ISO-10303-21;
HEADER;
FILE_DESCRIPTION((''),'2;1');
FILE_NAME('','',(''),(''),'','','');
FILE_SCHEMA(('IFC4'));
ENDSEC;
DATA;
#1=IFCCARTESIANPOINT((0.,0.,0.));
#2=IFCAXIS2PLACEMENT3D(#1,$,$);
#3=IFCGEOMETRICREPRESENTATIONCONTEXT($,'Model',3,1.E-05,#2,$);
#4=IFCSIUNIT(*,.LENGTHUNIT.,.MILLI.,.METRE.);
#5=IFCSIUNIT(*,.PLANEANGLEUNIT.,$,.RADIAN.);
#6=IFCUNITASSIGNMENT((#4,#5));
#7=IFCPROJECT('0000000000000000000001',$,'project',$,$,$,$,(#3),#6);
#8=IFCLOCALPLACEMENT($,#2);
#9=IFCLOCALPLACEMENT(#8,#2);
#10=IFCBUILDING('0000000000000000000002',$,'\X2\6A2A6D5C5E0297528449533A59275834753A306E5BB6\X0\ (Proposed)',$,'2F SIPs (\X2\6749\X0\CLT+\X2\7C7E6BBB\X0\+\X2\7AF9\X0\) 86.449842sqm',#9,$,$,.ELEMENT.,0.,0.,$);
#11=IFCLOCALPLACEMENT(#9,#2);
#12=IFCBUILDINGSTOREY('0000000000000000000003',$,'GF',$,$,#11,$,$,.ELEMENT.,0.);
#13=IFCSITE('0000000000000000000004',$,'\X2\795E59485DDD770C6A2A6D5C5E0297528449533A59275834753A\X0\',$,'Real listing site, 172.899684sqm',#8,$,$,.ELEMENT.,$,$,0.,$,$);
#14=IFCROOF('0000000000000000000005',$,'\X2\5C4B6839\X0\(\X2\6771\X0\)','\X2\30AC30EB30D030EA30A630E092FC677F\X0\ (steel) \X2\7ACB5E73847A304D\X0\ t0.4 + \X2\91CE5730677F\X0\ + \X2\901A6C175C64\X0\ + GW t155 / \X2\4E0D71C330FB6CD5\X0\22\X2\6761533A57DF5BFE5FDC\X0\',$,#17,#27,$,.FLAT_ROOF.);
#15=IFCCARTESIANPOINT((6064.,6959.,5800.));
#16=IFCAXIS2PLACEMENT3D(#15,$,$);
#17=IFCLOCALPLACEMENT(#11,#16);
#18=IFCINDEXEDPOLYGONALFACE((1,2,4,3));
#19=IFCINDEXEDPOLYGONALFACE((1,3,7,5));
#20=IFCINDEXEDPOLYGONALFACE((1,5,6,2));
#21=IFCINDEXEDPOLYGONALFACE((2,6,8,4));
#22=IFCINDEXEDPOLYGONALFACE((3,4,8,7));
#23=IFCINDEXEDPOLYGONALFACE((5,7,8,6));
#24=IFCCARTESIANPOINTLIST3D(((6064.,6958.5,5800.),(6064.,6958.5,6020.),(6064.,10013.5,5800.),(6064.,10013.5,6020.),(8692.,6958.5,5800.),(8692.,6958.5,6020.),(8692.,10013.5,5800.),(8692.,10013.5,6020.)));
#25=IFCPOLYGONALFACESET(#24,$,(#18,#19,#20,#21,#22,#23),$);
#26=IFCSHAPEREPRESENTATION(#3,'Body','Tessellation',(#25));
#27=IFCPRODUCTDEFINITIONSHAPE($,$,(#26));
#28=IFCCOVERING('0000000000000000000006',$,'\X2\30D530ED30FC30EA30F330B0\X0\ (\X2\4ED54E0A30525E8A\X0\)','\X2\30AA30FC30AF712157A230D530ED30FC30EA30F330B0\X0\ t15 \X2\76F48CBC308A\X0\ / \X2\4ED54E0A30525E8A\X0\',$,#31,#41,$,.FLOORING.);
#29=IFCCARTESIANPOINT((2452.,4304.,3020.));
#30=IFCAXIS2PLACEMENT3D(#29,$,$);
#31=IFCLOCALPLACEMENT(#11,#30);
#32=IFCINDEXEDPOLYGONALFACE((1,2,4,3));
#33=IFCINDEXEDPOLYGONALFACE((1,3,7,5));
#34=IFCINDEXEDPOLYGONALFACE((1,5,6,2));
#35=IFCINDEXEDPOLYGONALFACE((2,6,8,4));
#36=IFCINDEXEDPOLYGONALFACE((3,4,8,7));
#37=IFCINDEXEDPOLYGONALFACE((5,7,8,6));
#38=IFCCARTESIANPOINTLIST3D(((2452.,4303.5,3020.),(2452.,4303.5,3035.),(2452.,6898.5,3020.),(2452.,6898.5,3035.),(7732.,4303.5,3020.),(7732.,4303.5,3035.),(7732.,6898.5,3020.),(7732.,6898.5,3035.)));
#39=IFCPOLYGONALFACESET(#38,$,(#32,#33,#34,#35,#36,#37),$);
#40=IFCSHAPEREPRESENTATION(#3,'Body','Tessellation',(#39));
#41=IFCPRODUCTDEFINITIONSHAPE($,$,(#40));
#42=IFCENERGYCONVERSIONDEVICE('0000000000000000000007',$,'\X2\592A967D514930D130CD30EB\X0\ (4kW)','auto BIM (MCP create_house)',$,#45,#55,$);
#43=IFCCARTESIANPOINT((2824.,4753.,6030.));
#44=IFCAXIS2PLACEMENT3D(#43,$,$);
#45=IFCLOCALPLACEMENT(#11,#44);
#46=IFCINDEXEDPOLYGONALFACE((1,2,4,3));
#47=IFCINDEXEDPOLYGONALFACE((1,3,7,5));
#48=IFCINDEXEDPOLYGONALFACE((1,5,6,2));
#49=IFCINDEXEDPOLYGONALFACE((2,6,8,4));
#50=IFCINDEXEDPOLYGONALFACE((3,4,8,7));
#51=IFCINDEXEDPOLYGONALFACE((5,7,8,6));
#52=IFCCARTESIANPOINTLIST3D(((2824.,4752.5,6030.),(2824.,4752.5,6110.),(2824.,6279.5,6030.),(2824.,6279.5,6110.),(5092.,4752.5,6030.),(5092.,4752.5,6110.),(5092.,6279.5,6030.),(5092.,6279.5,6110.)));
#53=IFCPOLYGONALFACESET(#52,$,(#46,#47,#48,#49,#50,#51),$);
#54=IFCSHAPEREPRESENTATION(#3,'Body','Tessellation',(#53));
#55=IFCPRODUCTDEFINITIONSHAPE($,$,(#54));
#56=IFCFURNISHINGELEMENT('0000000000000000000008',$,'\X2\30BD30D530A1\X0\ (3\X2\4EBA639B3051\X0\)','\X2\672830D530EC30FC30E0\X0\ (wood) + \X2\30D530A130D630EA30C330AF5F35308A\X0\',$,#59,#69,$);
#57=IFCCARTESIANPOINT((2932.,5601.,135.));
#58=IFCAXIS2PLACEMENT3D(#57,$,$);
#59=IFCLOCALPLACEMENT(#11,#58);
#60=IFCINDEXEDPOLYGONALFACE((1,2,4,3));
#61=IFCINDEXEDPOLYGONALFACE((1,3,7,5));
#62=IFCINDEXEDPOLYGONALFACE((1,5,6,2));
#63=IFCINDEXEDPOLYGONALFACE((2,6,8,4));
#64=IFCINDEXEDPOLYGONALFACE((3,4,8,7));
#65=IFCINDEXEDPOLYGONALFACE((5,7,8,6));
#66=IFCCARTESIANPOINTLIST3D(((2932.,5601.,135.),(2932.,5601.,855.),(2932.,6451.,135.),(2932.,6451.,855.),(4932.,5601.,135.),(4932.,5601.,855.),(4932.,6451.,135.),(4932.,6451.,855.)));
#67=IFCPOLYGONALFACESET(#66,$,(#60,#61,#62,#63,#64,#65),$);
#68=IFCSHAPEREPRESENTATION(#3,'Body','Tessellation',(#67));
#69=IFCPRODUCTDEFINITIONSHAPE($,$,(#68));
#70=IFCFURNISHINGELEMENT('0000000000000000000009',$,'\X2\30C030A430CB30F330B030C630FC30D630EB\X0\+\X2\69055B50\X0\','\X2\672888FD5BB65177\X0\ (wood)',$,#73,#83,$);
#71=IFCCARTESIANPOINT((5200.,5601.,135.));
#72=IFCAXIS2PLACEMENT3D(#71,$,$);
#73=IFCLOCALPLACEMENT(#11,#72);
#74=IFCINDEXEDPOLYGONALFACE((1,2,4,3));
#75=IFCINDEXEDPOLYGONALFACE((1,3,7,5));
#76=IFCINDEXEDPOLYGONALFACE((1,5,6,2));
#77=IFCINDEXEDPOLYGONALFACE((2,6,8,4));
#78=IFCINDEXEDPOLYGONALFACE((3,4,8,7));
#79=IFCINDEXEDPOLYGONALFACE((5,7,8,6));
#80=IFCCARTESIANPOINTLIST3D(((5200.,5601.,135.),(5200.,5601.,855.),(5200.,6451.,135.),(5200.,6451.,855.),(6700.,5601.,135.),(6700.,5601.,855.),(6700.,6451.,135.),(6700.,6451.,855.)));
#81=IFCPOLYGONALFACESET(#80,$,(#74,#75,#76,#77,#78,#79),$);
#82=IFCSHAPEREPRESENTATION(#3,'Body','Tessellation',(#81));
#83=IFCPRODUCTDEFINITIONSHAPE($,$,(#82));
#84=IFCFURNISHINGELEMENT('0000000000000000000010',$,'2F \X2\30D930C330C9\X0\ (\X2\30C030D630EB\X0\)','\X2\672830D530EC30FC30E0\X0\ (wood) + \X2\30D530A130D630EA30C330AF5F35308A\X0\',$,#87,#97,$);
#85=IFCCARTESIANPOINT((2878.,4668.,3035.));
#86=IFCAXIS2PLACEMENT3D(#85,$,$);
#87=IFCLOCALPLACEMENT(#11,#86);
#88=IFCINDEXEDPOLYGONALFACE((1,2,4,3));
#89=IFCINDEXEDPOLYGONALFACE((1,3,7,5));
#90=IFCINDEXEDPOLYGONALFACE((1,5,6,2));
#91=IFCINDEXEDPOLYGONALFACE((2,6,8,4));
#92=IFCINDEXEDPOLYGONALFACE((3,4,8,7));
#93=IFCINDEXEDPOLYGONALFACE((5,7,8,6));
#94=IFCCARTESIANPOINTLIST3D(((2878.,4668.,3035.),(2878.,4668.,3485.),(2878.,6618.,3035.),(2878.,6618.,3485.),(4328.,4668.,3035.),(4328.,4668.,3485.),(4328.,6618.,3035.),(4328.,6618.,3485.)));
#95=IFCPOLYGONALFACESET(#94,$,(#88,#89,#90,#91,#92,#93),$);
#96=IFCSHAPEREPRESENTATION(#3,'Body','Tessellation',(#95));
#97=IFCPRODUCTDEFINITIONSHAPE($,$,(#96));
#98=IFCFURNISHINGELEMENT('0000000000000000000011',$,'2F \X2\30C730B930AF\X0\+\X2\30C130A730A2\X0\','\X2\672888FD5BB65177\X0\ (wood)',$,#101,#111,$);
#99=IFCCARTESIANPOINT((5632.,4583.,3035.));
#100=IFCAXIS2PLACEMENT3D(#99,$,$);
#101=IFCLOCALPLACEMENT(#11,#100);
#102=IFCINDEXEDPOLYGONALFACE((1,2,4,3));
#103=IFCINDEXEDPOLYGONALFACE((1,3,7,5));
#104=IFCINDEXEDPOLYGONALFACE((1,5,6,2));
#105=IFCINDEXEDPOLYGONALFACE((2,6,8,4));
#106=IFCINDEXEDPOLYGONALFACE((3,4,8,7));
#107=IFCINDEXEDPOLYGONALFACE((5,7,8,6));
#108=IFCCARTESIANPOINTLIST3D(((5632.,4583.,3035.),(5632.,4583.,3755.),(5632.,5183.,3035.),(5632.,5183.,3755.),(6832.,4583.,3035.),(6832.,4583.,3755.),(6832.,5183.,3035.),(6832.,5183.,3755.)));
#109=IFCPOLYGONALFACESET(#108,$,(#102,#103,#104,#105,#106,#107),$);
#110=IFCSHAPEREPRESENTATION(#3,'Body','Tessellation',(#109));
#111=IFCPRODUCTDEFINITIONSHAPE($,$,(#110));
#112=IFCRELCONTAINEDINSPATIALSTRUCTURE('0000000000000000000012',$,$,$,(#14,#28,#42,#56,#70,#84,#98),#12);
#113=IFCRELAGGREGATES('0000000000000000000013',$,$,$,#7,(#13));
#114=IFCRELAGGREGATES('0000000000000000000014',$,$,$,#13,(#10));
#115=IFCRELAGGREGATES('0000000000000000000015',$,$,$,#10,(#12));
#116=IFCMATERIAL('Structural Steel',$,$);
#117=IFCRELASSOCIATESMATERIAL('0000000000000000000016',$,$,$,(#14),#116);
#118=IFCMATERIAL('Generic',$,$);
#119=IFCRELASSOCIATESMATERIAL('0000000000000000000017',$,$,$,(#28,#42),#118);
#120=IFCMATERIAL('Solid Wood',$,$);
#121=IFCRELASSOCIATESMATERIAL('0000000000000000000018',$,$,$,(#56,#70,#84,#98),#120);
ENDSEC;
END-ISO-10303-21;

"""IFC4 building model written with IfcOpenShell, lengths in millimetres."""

from ifc_helpers import new_model, si_unit, frame, frame_2d, origin, place, context, project, spatial, rectangle, extrude, material, element, save


model = new_model("IFC4")

# Units and contexts
model_context = context("Model", 3, precision=1e-05, world=origin())
ifc_project = project(units=[si_unit("LENGTHUNIT", "METRE", prefix="MILLI"), si_unit("PLANEANGLEUNIT", "RADIAN")], contexts=[model_context])

# Site, building, storey
site_placement = place(None, origin())
site = spatial("IfcSite", under=ifc_project, at=site_placement, Name="神奈川県横浜市青葉区大場町", ObjectType="Real listing site, 172.899684sqm", CompositionType="ELEMENT", RefElevation=0.0)
building_placement = place(site_placement, origin())
building = spatial("IfcBuilding", under=site, at=building_placement, Name="横浜市青葉区大場町の家 (Proposed)", ObjectType="2F SIPs (杉CLT+籾殻+竹) 86.449842sqm", CompositionType="ELEMENT", ElevationOfRefHeight=0.0, ElevationOfTerrain=0.0)
storey_placement = place(building_placement, origin())
storey = spatial("IfcBuildingStorey", under=building, at=storey_placement, Name="GF", CompositionType="ELEMENT", Elevation=0.0)

# Shared definitions
ifc_material_1 = material(Name="Solid Wood")

# Roof
ifc_material_2 = material(Name="Structural Steel")
roof_1_placement = place(storey_placement, frame((6064.0, 6959.0, 5800.0)))
element("IfcRoof", 1, at=roof_1_placement, inside=storey, material=ifc_material_2, Name="屋根(東)", Description="ガルバリウム鋼板 (steel) 立平葺き t0.4 + 野地板 + 通気層 + GW t155 / 不燃・法22条区域対応", PredefinedType="FLAT_ROOF", context=model_context, shape_type="SweptSolid", body=[
    extrude(rectangle(XDim=2628.0, YDim=3055.0, at=frame_2d((1314.0, 1527.0))), frame((6064.0, 6959.0, 5800.0)), (0.0, 0.0, 1.0), 220.0),
])

# Covering
ifc_material_3 = material(Name="Generic")
covering_placement = place(storey_placement, frame((2452.0, 4304.0, 3020.0)))
element("IfcCovering", 2, at=covering_placement, inside=storey, material=ifc_material_3, Name="フローリング (仕上げ床)", Description="オーク無垢フローリング t15 直貼り / 仕上げ床", PredefinedType="FLOORING", context=model_context, shape_type="SweptSolid", body=[
    extrude(rectangle(XDim=5280.0, YDim=2595.0, at=frame_2d((2640.0, 1297.0))), frame((2452.0, 4304.0, 3020.0)), (0.0, 0.0, 1.0), 15.0),
])

# Energy conversion device
energy_conversion_device_placement = place(storey_placement, frame((2824.0, 4753.0, 6030.0)))
element("IfcEnergyConversionDevice", 3, at=energy_conversion_device_placement, inside=storey, material=ifc_material_3, Name="太陽光パネル (4kW)", Description="auto BIM (MCP create_house)", context=model_context, shape_type="SweptSolid", body=[
    extrude(rectangle(XDim=2268.0, YDim=1527.0, at=frame_2d((1134.0, 763.0))), frame((2824.0, 4753.0, 6030.0)), (0.0, 0.0, 1.0), 80.0),
])

# Furnishing elements
furnishing_1_placement = place(storey_placement, frame((2932.0, 5601.0, 135.0)))
element("IfcFurnishingElement", 4, at=furnishing_1_placement, inside=storey, material=ifc_material_1, Name="ソファ (3人掛け)", Description="木フレーム (wood) + ファブリック張り", context=model_context, shape_type="SweptSolid", body=[
    extrude(rectangle(XDim=2000.0, YDim=850.0, at=frame_2d((1000.0, 425.0))), frame((2932.0, 5601.0, 135.0)), (0.0, 0.0, 1.0), 720.0),
])
furnishing_2_placement = place(storey_placement, frame((5200.0, 5601.0, 135.0)))
element("IfcFurnishingElement", 5, at=furnishing_2_placement, inside=storey, material=ifc_material_1, Name="ダイニングテーブル+椅子", Description="木製家具 (wood)", context=model_context, shape_type="SweptSolid", body=[
    extrude(rectangle(XDim=1500.0, YDim=850.0, at=frame_2d((750.0, 425.0))), frame((5200.0, 5601.0, 135.0)), (0.0, 0.0, 1.0), 720.0),
])
furnishing_3_placement = place(storey_placement, frame((2878.0, 4668.0, 3035.0)))
element("IfcFurnishingElement", 6, at=furnishing_3_placement, inside=storey, material=ifc_material_1, Name="2F ベッド (ダブル)", Description="木フレーム (wood) + ファブリック張り", context=model_context, shape_type="SweptSolid", body=[
    extrude(rectangle(XDim=1450.0, YDim=1950.0, at=frame_2d((725.0, 975.0))), frame((2878.0, 4668.0, 3035.0)), (0.0, 0.0, 1.0), 450.0),
])
furnishing_4_placement = place(storey_placement, frame((5632.0, 4583.0, 3035.0)))
element("IfcFurnishingElement", 7, at=furnishing_4_placement, inside=storey, material=ifc_material_1, Name="2F デスク+チェア", Description="木製家具 (wood)", context=model_context, shape_type="SweptSolid", body=[
    extrude(rectangle(XDim=1200.0, YDim=600.0, at=frame_2d((600.0, 300.0))), frame((5632.0, 4583.0, 3035.0)), (0.0, 0.0, 1.0), 720.0),
])

save(model, "model.ifc")
